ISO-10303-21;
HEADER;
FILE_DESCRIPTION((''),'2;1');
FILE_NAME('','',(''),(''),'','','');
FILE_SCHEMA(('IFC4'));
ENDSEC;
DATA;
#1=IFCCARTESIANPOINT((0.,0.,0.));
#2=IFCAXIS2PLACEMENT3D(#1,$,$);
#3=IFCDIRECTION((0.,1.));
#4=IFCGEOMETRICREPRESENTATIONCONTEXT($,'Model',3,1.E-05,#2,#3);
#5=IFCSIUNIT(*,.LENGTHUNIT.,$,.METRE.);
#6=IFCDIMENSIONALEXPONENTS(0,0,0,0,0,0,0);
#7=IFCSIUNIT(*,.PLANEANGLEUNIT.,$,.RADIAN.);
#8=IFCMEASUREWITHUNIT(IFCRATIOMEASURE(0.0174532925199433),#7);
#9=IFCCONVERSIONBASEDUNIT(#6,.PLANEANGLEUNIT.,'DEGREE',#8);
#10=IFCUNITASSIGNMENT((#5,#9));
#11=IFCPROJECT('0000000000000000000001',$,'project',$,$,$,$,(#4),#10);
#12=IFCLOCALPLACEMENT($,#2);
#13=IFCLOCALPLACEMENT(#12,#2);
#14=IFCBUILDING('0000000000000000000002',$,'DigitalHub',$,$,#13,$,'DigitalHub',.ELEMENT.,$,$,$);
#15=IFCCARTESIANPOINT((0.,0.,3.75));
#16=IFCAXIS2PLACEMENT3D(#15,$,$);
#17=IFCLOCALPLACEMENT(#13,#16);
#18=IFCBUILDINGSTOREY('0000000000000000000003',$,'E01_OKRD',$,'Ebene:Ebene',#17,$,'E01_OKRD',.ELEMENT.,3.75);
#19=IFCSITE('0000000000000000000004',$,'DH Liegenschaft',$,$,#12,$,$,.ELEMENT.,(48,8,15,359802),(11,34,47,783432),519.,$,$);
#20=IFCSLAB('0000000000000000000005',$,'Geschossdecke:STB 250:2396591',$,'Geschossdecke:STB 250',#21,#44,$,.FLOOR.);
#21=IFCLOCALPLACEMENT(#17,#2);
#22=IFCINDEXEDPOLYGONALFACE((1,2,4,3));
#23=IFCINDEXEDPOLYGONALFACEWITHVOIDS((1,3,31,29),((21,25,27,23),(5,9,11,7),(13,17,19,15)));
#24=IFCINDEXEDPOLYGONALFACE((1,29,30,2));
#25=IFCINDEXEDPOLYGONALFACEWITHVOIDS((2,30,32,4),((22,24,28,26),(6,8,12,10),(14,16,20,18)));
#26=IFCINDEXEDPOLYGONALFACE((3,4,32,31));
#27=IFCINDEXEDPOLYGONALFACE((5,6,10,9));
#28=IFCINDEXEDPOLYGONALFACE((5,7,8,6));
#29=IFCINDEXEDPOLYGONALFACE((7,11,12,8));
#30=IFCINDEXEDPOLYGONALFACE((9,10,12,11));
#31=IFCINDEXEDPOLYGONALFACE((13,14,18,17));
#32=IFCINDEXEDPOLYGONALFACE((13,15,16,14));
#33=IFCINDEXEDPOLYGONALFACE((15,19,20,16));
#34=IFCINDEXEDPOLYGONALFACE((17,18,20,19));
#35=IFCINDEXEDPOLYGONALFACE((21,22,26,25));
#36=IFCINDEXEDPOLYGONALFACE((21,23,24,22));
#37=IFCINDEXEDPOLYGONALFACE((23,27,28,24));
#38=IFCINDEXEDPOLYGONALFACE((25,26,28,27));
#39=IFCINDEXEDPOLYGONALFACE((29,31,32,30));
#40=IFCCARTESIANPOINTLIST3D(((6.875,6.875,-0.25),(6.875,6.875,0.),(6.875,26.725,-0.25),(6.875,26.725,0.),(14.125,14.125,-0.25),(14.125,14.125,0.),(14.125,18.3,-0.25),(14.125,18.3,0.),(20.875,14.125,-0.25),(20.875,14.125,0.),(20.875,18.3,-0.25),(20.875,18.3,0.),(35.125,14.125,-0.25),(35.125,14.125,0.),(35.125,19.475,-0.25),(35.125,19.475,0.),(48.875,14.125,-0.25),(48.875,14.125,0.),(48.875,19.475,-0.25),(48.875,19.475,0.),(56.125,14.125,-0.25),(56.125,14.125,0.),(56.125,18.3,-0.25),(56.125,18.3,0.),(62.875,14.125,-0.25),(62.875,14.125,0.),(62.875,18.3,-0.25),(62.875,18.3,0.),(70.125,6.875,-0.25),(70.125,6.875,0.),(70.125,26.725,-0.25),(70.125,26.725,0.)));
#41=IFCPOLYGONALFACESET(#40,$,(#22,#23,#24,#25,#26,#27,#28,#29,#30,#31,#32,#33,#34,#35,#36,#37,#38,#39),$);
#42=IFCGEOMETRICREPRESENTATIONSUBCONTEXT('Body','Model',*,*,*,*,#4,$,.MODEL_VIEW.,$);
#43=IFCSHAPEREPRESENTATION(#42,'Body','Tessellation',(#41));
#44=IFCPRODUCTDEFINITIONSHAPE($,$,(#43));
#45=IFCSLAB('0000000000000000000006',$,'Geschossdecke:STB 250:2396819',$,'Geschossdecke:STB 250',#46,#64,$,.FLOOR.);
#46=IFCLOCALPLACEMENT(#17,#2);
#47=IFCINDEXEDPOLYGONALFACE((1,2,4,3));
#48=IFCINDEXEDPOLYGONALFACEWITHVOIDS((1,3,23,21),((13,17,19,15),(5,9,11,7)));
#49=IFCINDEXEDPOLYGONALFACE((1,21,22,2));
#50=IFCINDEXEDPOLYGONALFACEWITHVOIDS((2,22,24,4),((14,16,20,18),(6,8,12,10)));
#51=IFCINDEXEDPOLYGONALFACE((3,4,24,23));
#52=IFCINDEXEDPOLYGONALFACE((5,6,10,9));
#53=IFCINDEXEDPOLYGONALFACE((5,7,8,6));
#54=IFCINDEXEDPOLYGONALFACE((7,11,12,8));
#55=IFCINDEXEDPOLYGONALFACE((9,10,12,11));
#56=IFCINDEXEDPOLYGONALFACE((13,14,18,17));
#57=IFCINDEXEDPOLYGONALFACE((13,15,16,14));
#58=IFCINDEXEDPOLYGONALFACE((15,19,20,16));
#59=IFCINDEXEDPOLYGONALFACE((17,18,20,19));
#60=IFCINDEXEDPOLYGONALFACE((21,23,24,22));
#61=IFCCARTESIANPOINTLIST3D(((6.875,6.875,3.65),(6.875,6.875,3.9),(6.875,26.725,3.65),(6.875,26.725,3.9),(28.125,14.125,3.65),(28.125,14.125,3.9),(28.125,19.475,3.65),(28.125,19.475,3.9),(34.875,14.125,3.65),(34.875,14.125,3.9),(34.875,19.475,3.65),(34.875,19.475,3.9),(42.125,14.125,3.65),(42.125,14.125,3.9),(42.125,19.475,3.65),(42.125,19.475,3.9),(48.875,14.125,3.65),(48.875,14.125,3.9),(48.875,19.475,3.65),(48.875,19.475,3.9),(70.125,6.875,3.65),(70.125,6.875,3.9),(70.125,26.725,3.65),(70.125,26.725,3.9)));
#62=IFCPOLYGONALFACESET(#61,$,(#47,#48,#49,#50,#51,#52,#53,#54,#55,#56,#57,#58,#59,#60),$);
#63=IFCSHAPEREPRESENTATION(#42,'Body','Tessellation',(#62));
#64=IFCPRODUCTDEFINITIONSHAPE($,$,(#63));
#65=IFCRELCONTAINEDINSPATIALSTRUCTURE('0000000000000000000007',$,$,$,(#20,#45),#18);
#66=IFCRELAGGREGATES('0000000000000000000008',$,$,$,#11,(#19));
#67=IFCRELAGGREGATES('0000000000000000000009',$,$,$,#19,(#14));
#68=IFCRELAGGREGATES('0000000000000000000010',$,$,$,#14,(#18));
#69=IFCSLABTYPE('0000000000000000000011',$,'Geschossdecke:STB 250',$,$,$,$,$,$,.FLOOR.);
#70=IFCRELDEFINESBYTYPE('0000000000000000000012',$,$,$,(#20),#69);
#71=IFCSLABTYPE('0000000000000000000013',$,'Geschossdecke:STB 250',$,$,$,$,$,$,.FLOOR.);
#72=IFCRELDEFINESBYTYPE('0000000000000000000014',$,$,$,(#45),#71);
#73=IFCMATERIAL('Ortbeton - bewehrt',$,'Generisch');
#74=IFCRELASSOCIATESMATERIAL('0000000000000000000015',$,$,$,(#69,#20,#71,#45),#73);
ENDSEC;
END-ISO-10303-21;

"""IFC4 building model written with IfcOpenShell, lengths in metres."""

from ifc_helpers import new_model, entity, si_unit, converted_unit, direction, frame, origin, place, context, subcontext, project, spatial, indexed_curve, outline, extrude, material, type_object, element, save


model = new_model("IFC4")

# Units and contexts
model_context = context("Model", 3, precision=1e-05, world=origin(), true_north=direction((0.0, 1.0)))
body_context = subcontext(model_context, "Body", "Model", "MODEL_VIEW")
ifc_project = project(units=[si_unit("LENGTHUNIT", "METRE"), converted_unit("PLANEANGLEUNIT", "DEGREE", entity("IfcRatioMeasure", 0.0174532925199433), si_unit("PLANEANGLEUNIT", "RADIAN"), dimensions=[0, 0, 0, 0, 0, 0, 0])], contexts=[model_context])

# Site, building, storey
site_placement = place(None, frame((0.0, 0.0, 0.0)))
site = spatial("IfcSite", under=ifc_project, at=site_placement, Name="DH Liegenschaft", CompositionType="ELEMENT", RefLatitude=(48, 8, 15, 359802), RefLongitude=(11, 34, 47, 783432), RefElevation=519.0)
building_placement = place(site_placement, origin())
building = spatial("IfcBuilding", under=site, at=building_placement, Name="DigitalHub", LongName="DigitalHub", CompositionType="ELEMENT")
storey_placement = place(building_placement, frame((0.0, 0.0, 3.75)))
storey = spatial("IfcBuildingStorey", under=building, at=storey_placement, Name="E01_OKRD", ObjectType="Ebene:Ebene", LongName="E01_OKRD", CompositionType="ELEMENT", Elevation=3.75)

# Shared definitions
ifc_material = material(Name="Ortbeton - bewehrt", Category="Generisch")

# Slabs
slab_type_1 = type_object("IfcSlabType", Name="Geschossdecke:STB 250", PredefinedType="FLOOR", material=ifc_material)
slab_1_placement = place(storey_placement, origin())
element("IfcSlab", 1, at=slab_1_placement, inside=storey, type_object=slab_type_1, material=ifc_material, Name="Geschossdecke:STB 250:2396591", ObjectType="Geschossdecke:STB 250", PredefinedType="FLOOR", context=body_context, shape_type="SweptSolid", body=[
    extrude(outline(indexed_curve([(-31.625, -9.925), (31.625, -9.925), (31.625, 9.925), (-31.625, 9.925), (-31.625, -9.925)], self_intersect=False), holes=[indexed_curve([(-10.375, 2.675), (3.375, 2.675), (3.375, -2.675), (-10.375, -2.675), (-10.375, 2.675)], self_intersect=False), indexed_curve([(24.375, 2.675), (24.375, -1.5), (17.625, -1.5), (17.625, 2.675), (24.375, 2.675)], self_intersect=False), indexed_curve([(-24.375, 2.675), (-17.625, 2.675), (-17.625, -1.5), (-24.375, -1.5), (-24.375, 2.675)], self_intersect=False)]), frame((38.5, 16.8, -0.25), z_axis=(0.0, 0.0, 1.0), x_axis=(-1.0, 0.0, 0.0)), (0.0, 0.0, 1.0), 0.25),
])
slab_type_2 = type_object("IfcSlabType", Name="Geschossdecke:STB 250", PredefinedType="FLOOR", material=ifc_material)
slab_2_placement = place(storey_placement, origin())
element("IfcSlab", 2, at=slab_2_placement, inside=storey, type_object=slab_type_2, material=ifc_material, Name="Geschossdecke:STB 250:2396819", ObjectType="Geschossdecke:STB 250", PredefinedType="FLOOR", context=body_context, shape_type="SweptSolid", body=[
    extrude(outline(indexed_curve([(-31.625, -9.925), (31.625, -9.925), (31.625, 9.925), (-31.625, 9.925), (-31.625, -9.925)], self_intersect=False), holes=[indexed_curve([(-10.375, 2.675), (-3.625, 2.675), (-3.625, -2.675), (-10.375, -2.675), (-10.375, 2.675)], self_intersect=False), indexed_curve([(3.625, 2.675), (10.375, 2.675), (10.375, -2.675), (3.625, -2.675), (3.625, 2.675)], self_intersect=False)]), frame((38.5, 16.8, 3.65), z_axis=(0.0, 0.0, 1.0), x_axis=(-1.0, 0.0, 0.0)), (0.0, 0.0, 1.0), 0.25),
])

save(model, "model.ifc")
